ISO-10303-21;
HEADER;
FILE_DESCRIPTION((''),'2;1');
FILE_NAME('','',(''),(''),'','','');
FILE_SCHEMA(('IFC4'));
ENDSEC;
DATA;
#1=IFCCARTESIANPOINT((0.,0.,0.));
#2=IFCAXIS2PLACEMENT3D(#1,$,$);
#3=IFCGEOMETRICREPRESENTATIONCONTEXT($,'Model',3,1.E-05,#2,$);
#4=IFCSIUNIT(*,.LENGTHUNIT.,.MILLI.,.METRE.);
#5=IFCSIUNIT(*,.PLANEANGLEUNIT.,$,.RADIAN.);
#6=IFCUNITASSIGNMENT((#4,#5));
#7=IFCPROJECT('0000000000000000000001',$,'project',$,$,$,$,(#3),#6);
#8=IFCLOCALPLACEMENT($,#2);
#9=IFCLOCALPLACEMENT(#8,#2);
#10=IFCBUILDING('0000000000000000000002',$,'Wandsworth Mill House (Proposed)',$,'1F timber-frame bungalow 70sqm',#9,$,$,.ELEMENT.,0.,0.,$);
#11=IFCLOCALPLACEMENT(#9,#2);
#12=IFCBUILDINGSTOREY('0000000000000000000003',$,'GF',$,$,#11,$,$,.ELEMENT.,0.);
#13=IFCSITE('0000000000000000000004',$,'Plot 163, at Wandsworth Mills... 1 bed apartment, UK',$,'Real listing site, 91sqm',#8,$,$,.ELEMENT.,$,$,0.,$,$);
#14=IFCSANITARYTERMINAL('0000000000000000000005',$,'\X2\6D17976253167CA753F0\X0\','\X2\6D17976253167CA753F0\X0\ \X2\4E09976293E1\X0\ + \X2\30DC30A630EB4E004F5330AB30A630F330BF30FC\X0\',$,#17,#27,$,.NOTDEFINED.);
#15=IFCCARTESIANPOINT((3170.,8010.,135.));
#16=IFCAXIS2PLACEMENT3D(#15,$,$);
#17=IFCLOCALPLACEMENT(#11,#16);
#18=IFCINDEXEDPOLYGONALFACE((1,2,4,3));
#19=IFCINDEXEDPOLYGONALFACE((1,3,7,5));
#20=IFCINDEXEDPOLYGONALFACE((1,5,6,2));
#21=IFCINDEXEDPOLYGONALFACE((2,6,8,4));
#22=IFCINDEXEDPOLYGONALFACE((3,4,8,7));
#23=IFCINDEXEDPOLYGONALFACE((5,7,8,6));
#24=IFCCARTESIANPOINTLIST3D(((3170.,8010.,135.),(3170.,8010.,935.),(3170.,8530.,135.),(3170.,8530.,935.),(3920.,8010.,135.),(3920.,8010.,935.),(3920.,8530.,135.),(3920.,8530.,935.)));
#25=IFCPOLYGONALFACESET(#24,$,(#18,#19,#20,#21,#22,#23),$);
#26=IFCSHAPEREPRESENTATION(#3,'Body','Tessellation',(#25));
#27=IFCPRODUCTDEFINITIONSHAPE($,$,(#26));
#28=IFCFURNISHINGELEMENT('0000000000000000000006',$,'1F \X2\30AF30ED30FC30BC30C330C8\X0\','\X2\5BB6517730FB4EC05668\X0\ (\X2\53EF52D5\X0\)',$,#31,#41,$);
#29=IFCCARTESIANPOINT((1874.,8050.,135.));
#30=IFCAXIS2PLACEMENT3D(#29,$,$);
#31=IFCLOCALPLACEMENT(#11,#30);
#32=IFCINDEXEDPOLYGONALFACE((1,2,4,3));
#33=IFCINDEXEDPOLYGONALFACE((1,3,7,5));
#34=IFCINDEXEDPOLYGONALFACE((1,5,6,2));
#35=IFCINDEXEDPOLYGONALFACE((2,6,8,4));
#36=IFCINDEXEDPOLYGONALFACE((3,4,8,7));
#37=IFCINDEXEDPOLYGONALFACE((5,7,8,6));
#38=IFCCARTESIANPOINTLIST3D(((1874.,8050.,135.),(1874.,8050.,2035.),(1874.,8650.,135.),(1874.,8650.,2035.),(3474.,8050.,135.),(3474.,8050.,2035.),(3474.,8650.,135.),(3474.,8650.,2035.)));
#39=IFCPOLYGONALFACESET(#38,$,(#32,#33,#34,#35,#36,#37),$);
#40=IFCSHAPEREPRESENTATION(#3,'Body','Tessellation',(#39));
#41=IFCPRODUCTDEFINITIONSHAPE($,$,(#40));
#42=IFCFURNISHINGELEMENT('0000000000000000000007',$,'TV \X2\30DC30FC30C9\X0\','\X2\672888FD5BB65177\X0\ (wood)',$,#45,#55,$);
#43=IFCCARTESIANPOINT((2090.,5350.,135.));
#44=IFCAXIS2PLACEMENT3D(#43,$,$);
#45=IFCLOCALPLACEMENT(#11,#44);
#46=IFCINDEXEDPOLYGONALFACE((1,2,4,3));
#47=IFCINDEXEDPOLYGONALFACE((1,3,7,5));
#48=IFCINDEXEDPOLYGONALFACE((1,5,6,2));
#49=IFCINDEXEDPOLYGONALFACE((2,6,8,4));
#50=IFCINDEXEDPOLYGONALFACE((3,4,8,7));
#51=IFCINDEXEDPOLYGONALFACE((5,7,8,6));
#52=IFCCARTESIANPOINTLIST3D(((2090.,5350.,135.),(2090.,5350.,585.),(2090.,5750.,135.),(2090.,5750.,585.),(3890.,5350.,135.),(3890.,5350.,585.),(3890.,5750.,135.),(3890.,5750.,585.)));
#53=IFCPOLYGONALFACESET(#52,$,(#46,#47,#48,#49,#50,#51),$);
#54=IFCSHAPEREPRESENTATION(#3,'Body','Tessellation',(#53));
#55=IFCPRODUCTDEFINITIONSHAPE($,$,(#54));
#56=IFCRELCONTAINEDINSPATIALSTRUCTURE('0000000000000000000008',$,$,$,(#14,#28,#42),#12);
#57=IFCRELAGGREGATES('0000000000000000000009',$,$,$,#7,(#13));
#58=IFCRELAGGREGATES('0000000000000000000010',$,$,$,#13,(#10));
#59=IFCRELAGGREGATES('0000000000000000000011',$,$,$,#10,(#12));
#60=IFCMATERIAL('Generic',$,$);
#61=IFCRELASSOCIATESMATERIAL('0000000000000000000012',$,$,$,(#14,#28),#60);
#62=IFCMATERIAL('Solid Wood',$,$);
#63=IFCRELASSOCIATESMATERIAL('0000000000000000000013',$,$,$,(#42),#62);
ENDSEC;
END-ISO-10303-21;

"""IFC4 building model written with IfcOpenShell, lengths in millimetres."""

from ifc_helpers import new_model, si_unit, frame, frame_2d, origin, place, context, project, spatial, rectangle, extrude, material, element, save


model = new_model("IFC4")

# Units and contexts
model_context = context("Model", 3, precision=1e-05, world=origin())
ifc_project = project(units=[si_unit("LENGTHUNIT", "METRE", prefix="MILLI"), si_unit("PLANEANGLEUNIT", "RADIAN")], contexts=[model_context])

# Site, building, storey
site_placement = place(None, origin())
site = spatial("IfcSite", under=ifc_project, at=site_placement, Name="Plot 163, at Wandsworth Mills... 1 bed apartment, UK", ObjectType="Real listing site, 91sqm", CompositionType="ELEMENT", RefElevation=0.0)
building_placement = place(site_placement, origin())
building = spatial("IfcBuilding", under=site, at=building_placement, Name="Wandsworth Mill House (Proposed)", ObjectType="1F timber-frame bungalow 70sqm", CompositionType="ELEMENT", ElevationOfRefHeight=0.0, ElevationOfTerrain=0.0)
storey_placement = place(building_placement, origin())
storey = spatial("IfcBuildingStorey", under=building, at=storey_placement, Name="GF", CompositionType="ELEMENT", Elevation=0.0)

# Shared definitions
ifc_material_1 = material(Name="Solid Wood")

# Shared definitions
ifc_material_2 = material(Name="Generic")

# Sanitary terminal
sanitary_terminal_1_placement = place(storey_placement, frame((3170.0, 8010.0, 135.0)))
element("IfcSanitaryTerminal", 1, at=sanitary_terminal_1_placement, inside=storey, material=ifc_material_2, Name="洗面化粧台", Description="洗面化粧台 三面鏡 + ボウル一体カウンター", PredefinedType="NOTDEFINED", context=model_context, shape_type="SweptSolid", body=[
    extrude(rectangle(XDim=750.0, YDim=520.0, at=frame_2d((375.0, 260.0))), frame((3170.0, 8010.0, 135.0)), (0.0, 0.0, 1.0), 800.0),
])

# Furnishing elements
furnishing_1_placement = place(storey_placement, frame((1874.0, 8050.0, 135.0)))
element("IfcFurnishingElement", 2, at=furnishing_1_placement, inside=storey, material=ifc_material_2, Name="1F クローゼット", Description="家具・什器 (可動)", context=model_context, shape_type="SweptSolid", body=[
    extrude(rectangle(XDim=1600.0, YDim=600.0, at=frame_2d((800.0, 300.0))), frame((1874.0, 8050.0, 135.0)), (0.0, 0.0, 1.0), 1900.0),
])
furnishing_2_placement = place(storey_placement, frame((2090.0, 5350.0, 135.0)))
element("IfcFurnishingElement", 3, at=furnishing_2_placement, inside=storey, material=ifc_material_1, Name="TV ボード", Description="木製家具 (wood)", context=model_context, shape_type="SweptSolid", body=[
    extrude(rectangle(XDim=1800.0, YDim=400.0, at=frame_2d((900.0, 200.0))), frame((2090.0, 5350.0, 135.0)), (0.0, 0.0, 1.0), 450.0),
])

save(model, "model.ifc")
